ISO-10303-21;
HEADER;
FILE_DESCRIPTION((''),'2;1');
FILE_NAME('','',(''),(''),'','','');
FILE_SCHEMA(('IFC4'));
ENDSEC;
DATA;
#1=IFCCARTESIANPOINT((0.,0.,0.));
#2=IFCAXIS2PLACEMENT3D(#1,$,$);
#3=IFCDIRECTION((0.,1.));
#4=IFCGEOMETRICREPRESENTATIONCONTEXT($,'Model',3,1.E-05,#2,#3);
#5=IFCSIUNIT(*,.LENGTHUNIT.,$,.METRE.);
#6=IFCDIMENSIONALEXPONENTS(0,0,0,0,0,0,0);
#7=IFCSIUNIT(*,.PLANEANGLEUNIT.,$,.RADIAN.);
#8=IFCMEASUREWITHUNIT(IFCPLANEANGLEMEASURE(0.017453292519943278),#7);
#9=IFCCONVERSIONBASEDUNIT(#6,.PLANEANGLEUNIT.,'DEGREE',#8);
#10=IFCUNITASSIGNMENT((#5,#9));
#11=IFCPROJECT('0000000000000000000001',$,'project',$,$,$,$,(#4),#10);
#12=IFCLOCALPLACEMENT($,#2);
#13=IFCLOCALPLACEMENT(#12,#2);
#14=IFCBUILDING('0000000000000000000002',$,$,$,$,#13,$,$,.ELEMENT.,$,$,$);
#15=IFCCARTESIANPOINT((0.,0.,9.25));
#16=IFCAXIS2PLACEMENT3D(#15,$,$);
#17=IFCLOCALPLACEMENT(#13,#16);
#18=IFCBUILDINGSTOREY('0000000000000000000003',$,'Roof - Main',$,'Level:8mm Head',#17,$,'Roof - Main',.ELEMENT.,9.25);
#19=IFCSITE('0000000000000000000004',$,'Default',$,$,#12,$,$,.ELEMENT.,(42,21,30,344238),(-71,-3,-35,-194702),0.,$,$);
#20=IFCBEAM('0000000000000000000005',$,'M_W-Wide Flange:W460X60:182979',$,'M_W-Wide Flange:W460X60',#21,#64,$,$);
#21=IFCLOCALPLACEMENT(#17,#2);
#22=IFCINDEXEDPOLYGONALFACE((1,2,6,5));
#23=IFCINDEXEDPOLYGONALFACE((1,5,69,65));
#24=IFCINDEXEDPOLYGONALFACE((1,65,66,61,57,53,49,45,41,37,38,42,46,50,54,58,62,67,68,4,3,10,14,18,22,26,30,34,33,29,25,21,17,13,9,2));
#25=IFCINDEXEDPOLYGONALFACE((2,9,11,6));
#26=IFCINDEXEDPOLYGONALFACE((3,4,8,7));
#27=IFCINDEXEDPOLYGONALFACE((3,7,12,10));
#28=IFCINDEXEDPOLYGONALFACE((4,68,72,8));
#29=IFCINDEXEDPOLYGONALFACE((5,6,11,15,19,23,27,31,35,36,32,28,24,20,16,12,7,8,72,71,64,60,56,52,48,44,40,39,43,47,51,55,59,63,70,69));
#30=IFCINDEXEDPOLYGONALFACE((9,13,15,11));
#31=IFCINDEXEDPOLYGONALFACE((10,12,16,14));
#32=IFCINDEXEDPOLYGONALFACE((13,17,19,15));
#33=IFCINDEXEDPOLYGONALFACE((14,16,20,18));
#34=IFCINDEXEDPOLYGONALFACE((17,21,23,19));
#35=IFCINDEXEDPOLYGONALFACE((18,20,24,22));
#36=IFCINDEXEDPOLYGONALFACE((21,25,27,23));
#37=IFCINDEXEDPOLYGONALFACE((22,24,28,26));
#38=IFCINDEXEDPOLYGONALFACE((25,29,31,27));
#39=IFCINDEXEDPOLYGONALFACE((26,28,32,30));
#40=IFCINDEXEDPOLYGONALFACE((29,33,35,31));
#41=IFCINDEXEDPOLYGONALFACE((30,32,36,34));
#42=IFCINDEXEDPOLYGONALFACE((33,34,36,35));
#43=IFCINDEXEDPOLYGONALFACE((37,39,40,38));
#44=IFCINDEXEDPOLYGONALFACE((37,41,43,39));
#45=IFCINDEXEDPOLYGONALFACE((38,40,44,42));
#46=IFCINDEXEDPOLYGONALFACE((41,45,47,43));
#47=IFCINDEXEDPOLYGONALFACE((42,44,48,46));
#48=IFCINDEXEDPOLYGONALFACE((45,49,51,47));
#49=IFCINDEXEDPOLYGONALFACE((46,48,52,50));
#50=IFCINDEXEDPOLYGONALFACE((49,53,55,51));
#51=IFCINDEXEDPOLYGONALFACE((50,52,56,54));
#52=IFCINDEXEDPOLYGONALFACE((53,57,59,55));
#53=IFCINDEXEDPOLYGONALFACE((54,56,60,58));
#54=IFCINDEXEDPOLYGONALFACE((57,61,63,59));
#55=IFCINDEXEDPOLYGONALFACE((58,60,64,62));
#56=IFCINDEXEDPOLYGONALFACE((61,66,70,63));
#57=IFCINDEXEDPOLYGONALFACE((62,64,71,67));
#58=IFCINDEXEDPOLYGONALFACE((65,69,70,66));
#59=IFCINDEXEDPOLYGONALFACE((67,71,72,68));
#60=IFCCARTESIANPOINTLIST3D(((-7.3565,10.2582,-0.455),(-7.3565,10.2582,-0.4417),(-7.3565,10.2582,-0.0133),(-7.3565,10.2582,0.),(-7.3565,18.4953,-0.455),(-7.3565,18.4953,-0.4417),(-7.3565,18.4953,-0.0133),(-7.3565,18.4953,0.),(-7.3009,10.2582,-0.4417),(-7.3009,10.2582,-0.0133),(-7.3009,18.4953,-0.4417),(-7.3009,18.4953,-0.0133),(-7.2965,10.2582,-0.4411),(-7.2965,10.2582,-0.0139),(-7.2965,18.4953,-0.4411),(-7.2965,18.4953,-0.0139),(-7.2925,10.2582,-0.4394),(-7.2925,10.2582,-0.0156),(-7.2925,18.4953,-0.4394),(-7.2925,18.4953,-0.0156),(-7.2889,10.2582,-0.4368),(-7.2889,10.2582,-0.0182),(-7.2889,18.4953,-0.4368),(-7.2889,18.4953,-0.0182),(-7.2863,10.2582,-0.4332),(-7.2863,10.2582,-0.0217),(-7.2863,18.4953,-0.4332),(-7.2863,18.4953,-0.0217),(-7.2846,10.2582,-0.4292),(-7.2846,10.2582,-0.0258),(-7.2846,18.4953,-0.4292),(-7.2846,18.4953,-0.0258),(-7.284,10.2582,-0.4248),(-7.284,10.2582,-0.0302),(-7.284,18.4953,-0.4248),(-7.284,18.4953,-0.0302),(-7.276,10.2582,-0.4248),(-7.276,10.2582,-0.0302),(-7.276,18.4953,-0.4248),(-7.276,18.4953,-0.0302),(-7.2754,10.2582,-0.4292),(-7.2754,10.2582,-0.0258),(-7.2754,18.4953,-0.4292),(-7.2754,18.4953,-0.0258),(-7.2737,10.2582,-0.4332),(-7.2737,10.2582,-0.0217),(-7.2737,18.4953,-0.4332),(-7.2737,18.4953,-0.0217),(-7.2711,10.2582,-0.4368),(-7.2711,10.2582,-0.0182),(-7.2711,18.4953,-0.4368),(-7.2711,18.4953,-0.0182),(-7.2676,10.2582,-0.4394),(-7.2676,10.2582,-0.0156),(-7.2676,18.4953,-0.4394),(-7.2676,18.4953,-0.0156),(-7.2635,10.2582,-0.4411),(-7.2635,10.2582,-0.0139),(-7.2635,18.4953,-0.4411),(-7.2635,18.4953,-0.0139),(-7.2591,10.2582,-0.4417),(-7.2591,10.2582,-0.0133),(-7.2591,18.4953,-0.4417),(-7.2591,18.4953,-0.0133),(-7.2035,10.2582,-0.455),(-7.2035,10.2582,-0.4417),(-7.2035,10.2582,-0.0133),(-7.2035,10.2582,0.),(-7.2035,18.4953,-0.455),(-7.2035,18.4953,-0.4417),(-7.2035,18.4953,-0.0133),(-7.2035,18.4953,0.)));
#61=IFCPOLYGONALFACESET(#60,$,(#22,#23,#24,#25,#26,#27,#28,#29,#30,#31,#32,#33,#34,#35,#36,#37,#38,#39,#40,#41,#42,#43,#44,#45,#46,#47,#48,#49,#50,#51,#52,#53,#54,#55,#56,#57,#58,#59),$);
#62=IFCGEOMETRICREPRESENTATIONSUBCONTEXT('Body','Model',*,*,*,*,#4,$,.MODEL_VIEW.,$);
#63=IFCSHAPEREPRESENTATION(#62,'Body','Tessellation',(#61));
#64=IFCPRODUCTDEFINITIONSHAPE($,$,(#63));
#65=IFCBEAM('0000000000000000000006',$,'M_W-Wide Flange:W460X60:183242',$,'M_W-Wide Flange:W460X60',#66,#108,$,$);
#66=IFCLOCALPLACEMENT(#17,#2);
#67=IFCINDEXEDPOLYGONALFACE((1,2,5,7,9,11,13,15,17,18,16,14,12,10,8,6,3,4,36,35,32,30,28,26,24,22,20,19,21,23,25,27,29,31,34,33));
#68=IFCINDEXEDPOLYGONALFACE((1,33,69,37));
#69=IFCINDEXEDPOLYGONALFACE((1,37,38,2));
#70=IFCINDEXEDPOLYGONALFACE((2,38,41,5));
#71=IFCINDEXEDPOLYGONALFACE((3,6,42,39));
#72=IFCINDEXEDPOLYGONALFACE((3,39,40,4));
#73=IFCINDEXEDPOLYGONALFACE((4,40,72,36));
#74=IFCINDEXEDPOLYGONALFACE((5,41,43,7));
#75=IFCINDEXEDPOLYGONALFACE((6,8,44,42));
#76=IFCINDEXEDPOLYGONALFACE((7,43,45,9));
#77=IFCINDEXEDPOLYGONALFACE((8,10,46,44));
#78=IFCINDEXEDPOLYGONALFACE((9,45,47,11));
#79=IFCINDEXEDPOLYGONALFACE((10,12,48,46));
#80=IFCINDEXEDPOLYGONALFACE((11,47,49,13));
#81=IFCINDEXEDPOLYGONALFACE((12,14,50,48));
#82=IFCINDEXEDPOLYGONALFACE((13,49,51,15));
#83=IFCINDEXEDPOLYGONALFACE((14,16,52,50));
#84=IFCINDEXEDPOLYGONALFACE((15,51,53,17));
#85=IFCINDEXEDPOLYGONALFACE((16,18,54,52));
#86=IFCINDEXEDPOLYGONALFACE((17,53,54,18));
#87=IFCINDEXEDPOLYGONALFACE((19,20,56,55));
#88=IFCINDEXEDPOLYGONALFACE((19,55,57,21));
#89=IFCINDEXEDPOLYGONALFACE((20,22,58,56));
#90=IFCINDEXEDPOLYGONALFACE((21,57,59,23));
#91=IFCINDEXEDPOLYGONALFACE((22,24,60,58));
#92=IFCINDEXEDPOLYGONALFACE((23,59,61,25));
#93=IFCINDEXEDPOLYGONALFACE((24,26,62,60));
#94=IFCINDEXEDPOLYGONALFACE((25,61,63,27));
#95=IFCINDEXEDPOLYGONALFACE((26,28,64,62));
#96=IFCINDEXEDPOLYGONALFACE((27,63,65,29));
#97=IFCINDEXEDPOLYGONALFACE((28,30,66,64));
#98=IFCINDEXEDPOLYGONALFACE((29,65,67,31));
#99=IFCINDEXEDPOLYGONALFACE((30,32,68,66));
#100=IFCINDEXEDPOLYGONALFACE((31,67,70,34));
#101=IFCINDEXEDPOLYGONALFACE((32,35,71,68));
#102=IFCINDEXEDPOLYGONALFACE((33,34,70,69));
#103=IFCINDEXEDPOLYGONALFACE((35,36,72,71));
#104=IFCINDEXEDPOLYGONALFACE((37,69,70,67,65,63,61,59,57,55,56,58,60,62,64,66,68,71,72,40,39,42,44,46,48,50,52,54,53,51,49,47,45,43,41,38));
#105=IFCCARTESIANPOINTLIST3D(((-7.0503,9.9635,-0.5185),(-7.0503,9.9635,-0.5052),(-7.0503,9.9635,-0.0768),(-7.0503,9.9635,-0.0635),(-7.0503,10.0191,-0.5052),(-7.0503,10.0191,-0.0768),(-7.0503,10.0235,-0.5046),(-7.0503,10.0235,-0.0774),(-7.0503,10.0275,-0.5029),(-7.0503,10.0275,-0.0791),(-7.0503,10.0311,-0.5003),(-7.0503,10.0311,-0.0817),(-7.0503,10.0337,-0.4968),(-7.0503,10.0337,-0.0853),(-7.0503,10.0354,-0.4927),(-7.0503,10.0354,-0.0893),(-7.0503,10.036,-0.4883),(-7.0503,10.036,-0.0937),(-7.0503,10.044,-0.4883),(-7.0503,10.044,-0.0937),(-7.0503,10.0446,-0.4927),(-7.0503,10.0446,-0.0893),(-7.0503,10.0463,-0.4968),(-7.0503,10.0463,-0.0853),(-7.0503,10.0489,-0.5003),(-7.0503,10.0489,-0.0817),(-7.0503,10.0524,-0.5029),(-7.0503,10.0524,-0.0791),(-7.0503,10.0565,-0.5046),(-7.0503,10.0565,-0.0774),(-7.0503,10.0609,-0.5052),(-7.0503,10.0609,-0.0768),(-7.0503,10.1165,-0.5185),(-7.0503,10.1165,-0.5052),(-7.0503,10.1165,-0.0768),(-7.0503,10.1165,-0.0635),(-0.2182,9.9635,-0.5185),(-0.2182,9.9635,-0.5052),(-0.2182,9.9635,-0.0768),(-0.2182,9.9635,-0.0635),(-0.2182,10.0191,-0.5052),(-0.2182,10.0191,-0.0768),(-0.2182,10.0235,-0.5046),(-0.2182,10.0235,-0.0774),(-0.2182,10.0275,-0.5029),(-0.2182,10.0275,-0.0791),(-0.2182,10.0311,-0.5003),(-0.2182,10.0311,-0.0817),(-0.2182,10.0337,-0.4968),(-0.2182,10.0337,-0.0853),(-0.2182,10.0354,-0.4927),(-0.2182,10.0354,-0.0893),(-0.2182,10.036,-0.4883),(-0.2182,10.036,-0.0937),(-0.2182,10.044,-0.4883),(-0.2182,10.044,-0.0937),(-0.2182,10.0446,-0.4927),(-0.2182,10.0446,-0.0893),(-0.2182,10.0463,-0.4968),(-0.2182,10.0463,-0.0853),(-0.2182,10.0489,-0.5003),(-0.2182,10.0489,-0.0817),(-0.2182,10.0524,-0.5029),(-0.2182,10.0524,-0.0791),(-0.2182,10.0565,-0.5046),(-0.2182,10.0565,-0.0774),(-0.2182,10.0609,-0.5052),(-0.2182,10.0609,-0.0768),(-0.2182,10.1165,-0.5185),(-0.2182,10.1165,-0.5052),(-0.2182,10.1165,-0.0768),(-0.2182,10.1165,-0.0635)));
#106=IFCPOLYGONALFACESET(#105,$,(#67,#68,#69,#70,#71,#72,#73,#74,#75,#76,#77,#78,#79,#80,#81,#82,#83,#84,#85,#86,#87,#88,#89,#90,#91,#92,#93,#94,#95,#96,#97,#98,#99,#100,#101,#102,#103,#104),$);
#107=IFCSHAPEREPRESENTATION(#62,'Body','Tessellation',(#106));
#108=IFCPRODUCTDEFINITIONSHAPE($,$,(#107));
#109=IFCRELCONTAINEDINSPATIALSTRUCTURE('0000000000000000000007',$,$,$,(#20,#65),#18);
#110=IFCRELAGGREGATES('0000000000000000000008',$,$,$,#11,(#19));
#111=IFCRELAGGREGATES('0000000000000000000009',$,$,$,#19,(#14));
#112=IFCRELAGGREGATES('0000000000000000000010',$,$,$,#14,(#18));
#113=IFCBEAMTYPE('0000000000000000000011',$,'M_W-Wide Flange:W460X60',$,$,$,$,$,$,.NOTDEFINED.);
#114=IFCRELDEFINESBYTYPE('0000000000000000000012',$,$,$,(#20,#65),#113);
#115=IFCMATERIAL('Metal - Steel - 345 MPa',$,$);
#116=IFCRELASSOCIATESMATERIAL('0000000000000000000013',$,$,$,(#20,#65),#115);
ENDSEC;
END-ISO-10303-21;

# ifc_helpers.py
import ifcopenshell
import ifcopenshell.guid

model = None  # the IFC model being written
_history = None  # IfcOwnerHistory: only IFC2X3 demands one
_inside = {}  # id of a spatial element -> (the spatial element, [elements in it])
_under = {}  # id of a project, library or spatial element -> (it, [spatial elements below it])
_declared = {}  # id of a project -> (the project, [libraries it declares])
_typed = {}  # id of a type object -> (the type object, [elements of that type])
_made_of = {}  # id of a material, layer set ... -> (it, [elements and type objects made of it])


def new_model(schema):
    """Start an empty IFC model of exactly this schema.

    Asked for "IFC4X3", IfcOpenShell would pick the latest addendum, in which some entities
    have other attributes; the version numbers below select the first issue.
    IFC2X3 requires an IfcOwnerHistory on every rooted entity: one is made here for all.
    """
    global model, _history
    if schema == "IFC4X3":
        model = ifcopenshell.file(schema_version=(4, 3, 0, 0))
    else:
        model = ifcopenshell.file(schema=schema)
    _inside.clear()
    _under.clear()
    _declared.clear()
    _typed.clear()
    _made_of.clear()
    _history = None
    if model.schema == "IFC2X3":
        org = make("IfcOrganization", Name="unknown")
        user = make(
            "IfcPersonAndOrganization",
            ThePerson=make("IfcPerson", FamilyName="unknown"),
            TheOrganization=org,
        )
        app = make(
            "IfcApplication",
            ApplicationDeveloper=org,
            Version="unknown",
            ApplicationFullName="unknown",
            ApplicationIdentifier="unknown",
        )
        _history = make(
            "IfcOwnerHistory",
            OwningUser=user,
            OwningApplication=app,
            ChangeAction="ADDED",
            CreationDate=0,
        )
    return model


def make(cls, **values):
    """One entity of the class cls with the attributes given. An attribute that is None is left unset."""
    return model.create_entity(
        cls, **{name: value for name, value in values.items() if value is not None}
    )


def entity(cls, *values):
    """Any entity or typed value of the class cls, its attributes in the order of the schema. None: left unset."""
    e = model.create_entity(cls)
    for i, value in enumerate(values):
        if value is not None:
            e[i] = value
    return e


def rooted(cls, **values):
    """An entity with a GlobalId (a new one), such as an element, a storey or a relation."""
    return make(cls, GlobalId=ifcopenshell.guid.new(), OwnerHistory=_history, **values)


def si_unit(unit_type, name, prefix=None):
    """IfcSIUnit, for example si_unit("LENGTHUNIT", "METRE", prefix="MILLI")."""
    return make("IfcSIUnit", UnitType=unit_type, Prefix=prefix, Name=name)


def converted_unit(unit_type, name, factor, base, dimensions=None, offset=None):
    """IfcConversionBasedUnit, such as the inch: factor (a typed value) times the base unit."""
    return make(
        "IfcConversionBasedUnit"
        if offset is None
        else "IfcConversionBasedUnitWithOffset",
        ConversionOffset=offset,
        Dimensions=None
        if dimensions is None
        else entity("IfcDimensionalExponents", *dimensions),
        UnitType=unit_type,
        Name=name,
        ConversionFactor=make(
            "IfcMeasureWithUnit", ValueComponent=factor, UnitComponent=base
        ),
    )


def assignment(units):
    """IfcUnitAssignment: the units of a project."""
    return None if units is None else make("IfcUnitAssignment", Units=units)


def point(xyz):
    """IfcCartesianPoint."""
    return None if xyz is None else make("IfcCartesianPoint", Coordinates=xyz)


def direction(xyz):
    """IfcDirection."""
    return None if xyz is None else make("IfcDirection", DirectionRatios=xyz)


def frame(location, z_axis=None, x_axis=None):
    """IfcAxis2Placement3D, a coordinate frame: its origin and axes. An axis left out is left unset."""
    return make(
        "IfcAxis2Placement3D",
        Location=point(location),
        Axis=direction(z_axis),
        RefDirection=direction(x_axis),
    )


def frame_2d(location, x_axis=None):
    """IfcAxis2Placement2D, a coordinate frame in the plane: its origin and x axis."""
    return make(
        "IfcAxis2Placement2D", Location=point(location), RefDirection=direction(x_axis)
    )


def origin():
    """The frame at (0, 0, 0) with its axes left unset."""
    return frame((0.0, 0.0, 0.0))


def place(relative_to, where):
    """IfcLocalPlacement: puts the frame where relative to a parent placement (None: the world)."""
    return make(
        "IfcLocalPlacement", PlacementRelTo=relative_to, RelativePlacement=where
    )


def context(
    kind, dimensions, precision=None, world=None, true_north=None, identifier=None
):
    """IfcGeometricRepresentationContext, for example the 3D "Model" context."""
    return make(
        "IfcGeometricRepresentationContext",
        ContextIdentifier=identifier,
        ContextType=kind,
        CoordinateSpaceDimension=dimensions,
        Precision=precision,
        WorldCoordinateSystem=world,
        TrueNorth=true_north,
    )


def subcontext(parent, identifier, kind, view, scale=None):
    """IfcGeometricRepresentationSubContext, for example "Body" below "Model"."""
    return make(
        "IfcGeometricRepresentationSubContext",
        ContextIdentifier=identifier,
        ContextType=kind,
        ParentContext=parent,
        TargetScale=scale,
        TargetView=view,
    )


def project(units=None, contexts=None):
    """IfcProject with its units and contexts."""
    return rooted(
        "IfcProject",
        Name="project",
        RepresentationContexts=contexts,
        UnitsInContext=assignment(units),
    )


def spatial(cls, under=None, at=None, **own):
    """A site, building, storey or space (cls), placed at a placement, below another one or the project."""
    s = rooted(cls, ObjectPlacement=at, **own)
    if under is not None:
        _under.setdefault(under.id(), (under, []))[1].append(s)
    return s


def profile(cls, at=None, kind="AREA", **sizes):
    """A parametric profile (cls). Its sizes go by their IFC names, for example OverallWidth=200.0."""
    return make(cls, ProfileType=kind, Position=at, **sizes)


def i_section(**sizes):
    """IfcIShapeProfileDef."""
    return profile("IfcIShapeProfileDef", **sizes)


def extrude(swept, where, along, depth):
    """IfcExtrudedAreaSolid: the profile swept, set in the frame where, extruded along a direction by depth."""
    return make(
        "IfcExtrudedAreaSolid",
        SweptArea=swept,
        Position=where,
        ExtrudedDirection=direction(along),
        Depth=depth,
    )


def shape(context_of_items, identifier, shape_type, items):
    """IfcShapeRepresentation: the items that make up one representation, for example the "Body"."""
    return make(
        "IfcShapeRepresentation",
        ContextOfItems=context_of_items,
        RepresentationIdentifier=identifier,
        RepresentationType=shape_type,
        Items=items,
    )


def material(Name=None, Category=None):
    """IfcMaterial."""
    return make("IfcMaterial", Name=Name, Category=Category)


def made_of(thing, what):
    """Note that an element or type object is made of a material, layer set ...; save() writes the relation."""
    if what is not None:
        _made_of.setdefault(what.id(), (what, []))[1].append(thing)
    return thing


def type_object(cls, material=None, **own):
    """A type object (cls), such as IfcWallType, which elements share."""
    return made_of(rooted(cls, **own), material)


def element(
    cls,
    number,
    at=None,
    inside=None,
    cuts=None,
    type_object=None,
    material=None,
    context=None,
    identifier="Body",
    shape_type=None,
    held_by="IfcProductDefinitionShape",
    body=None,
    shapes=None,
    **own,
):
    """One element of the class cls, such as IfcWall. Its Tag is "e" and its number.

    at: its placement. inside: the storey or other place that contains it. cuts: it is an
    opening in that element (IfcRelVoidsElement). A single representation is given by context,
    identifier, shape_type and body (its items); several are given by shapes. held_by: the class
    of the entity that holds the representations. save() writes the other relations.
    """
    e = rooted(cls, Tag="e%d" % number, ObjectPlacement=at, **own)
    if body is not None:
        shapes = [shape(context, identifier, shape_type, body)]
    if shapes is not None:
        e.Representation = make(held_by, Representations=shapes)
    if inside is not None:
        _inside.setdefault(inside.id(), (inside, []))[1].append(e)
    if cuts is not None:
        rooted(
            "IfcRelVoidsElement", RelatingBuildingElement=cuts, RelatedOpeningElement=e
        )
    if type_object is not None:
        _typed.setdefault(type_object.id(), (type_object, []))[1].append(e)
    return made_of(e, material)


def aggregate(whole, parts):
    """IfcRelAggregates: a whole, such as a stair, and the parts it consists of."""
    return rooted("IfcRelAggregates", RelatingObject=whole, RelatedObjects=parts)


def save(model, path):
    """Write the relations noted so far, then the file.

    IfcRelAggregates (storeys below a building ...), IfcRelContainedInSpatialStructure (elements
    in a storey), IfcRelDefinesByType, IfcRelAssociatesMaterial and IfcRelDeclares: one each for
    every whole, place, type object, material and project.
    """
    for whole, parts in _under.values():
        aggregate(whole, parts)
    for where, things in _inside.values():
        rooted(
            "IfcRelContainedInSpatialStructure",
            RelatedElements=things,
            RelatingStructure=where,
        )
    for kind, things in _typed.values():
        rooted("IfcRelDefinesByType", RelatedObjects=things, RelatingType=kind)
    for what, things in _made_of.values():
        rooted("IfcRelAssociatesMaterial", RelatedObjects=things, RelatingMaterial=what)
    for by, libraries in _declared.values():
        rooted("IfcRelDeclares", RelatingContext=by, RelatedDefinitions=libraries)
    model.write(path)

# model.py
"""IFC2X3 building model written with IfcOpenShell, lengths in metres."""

from ifc_helpers import new_model, entity, si_unit, converted_unit, direction, frame, frame_2d, origin, place, context, subcontext, project, spatial, i_section, extrude, material, type_object, element, save


model = new_model("IFC2X3")

# Units and contexts
model_context = context("Model", 3, precision=1e-05, world=origin(), true_north=direction((0.0, 1.0)))
body_context = subcontext(model_context, "Body", "Model", "MODEL_VIEW")
ifc_project = project(units=[si_unit("LENGTHUNIT", "METRE"), converted_unit("PLANEANGLEUNIT", "DEGREE", entity("IfcPlaneAngleMeasure", 0.017453292519943278), si_unit("PLANEANGLEUNIT", "RADIAN"), dimensions=[0, 0, 0, 0, 0, 0, 0])], contexts=[model_context])

# Site, building, storey
site_placement = place(None, origin())
site = spatial("IfcSite", under=ifc_project, at=site_placement, Name="Default", CompositionType="ELEMENT", RefLatitude=(42, 21, 30, 344238), RefLongitude=(-71, -3, -35, -194702), RefElevation=0.0)
building_placement = place(site_placement, origin())
building = spatial("IfcBuilding", under=site, at=building_placement, CompositionType="ELEMENT")
storey_placement = place(building_placement, frame((0.0, 0.0, 9.25)))
storey = spatial("IfcBuildingStorey", under=building, at=storey_placement, Name="Roof - Main", ObjectType="Level:8mm Head", LongName="Roof - Main", CompositionType="ELEMENT", Elevation=9.25)

# Beams
ifc_material_1 = material(Name="Metal - Steel - 345 MPa")
beam_type_1 = type_object("IfcBeamType", Name="M_W-Wide Flange:W460X60", PredefinedType="NOTDEFINED")
beam_1_placement = place(storey_placement, frame((-7.28, 10.04, 0.0), z_axis=(0.0, 0.0, 1.0), x_axis=(0.0, 1.0, 0.0)))
element("IfcBeam", 1, at=beam_1_placement, inside=storey, type_object=beam_type_1, material=ifc_material_1, Name="M_W-Wide Flange:W460X60:182979", ObjectType="M_W-Wide Flange:W460X60", context=body_context, shape_type="SweptSolid", body=[
    extrude(i_section(OverallWidth=0.153, OverallDepth=0.455, WebThickness=0.008, FlangeThickness=0.0133, FilletRadius=0.0169, at=frame_2d((0.0, 0.0), x_axis=(0.0, 1.0))), frame((0.2182, 0.0, -0.2275), z_axis=(1.0, 0.0, 0.0), x_axis=(0.0, 0.0, -1.0)), (0.0, 0.0, 1.0), 8.2371),
])
beam_2_placement = place(storey_placement, frame((0.0, 10.04, -0.0635), z_axis=(0.0, 0.0, 1.0), x_axis=(-1.0, 0.0, 0.0)))
element("IfcBeam", 2, at=beam_2_placement, inside=storey, type_object=beam_type_1, material=ifc_material_1, Name="M_W-Wide Flange:W460X60:183242", ObjectType="M_W-Wide Flange:W460X60", context=body_context, shape_type="SweptSolid", body=[
    extrude(i_section(OverallWidth=0.153, OverallDepth=0.455, WebThickness=0.008, FlangeThickness=0.0133, FilletRadius=0.0169, at=frame_2d((0.0, 0.0), x_axis=(0.0, 1.0))), frame((0.2182, 0.0, -0.2275), z_axis=(1.0, 0.0, 0.0), x_axis=(0.0, 0.0, -1.0)), (0.0, 0.0, 1.0), 6.8321),
])

save(model, "model.ifc")
